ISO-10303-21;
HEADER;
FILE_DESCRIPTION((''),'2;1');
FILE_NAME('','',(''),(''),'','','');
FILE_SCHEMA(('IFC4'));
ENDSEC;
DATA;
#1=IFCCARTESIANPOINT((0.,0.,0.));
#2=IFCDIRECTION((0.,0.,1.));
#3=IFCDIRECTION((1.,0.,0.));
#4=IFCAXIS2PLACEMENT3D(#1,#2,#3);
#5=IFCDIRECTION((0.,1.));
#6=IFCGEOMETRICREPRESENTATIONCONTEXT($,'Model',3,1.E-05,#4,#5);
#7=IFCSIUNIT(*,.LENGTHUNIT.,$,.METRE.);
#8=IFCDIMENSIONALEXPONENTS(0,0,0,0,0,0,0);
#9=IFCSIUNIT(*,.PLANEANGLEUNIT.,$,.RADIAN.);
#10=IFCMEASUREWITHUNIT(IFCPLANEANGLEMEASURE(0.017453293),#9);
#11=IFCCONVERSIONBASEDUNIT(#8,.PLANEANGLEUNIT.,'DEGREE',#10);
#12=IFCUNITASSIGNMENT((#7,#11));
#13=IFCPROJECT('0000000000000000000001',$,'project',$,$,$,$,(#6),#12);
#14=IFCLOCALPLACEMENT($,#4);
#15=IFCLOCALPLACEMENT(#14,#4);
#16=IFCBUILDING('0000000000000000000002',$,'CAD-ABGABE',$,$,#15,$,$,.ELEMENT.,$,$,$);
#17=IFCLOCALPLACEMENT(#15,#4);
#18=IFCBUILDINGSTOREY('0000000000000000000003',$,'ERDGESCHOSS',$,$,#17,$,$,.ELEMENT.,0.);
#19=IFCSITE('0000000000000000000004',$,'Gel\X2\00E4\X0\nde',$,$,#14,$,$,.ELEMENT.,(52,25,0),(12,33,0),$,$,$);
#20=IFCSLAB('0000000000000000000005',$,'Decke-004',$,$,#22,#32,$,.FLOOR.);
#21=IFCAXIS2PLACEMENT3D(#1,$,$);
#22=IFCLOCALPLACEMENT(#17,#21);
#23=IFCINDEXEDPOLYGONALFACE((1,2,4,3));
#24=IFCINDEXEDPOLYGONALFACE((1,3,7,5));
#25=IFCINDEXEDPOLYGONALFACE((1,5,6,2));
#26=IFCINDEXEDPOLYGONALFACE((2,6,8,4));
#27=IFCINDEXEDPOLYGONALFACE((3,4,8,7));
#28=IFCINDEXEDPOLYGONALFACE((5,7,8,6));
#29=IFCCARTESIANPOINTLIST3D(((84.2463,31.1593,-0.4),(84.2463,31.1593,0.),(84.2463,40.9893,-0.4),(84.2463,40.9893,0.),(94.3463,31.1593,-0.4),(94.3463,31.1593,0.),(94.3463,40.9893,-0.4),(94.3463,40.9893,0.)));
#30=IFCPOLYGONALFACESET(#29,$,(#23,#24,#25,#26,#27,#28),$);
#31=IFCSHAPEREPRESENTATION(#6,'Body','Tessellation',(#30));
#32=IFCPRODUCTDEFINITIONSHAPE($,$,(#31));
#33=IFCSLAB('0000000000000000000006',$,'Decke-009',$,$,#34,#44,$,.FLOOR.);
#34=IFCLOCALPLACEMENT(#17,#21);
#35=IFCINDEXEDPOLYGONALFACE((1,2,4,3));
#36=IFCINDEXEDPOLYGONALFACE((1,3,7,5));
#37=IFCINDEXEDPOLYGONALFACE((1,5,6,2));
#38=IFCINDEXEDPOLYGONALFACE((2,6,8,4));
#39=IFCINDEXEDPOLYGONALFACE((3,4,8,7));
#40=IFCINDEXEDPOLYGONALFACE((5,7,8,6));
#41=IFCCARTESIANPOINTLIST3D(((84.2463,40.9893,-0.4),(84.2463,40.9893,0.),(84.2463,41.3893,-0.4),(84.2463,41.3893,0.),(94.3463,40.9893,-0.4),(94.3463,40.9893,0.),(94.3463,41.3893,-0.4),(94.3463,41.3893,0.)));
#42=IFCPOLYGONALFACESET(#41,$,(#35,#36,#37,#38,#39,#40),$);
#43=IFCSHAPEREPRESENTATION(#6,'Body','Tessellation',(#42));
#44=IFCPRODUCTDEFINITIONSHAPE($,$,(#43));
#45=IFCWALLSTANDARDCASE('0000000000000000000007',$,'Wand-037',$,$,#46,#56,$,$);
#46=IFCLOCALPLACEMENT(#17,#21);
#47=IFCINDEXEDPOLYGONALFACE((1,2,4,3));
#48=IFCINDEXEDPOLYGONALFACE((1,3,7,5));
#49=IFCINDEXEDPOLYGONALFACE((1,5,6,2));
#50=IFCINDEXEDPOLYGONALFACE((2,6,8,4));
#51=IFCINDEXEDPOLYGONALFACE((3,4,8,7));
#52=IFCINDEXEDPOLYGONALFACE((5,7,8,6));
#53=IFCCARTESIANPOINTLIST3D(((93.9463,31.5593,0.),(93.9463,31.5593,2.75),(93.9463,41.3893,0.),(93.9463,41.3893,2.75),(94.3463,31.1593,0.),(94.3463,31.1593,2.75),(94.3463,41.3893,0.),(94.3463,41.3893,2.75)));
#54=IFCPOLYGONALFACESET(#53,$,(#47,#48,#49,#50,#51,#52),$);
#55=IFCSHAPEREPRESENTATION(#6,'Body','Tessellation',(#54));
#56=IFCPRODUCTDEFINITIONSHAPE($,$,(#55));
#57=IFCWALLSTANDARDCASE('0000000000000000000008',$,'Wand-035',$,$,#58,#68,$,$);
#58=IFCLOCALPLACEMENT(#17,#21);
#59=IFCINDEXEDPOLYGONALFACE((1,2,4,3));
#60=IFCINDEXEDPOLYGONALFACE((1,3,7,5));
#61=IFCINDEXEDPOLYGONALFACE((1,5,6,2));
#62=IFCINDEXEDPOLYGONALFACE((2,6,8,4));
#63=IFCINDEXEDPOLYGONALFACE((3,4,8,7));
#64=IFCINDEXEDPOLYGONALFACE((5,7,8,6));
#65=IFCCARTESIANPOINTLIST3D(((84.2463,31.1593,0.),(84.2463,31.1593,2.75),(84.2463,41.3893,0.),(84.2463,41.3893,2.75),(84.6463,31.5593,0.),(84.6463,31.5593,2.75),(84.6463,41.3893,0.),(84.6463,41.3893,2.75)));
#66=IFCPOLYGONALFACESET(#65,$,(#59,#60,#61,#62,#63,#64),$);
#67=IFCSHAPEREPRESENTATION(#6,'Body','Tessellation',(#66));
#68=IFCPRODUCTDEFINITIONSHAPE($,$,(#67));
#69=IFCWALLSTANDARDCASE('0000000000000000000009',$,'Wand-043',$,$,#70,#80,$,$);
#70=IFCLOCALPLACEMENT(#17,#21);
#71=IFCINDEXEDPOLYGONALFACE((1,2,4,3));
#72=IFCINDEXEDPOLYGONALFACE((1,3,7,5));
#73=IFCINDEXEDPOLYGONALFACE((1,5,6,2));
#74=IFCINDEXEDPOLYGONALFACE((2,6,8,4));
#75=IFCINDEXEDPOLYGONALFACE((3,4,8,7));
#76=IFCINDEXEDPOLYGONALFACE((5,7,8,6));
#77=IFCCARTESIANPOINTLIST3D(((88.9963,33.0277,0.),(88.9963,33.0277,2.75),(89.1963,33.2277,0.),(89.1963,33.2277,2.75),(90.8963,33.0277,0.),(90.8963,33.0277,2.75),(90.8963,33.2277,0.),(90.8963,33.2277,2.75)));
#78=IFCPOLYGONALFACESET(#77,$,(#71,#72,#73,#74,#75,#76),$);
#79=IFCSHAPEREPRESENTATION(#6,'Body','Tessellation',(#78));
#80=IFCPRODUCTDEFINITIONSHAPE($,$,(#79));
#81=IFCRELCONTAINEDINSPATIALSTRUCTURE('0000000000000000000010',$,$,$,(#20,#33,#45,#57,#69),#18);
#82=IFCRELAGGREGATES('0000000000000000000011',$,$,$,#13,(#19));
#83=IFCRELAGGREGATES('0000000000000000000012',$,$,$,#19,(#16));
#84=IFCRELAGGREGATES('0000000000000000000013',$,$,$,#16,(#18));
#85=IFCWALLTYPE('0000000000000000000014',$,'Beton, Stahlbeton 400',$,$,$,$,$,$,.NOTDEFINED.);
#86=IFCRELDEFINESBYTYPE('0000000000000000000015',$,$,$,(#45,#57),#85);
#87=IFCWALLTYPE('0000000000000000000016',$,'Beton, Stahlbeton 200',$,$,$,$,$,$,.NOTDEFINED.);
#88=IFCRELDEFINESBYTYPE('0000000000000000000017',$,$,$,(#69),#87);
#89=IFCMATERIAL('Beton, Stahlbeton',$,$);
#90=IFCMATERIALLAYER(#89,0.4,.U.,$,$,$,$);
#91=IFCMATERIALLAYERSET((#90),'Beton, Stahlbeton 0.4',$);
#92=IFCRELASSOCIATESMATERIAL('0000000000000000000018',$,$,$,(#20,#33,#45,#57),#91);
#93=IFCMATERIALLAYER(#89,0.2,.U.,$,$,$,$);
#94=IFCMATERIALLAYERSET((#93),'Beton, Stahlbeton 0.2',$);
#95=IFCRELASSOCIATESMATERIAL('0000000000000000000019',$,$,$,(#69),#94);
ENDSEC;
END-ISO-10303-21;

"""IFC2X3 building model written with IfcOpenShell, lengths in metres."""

from ifc_helpers import new_model, entity, si_unit, converted_unit, direction, frame, origin_with_axes, place, context, project, spatial, polyline, outline, extrude, material, layer, layer_set, layer_usage, type_object, element, save


model = new_model("IFC2X3")

# Units and contexts
model_context = context("Model", 3, precision=1e-05, world=origin_with_axes(), true_north=direction((0.0, 1.0)))
ifc_project = project(units=[si_unit("LENGTHUNIT", "METRE"), converted_unit("PLANEANGLEUNIT", "DEGREE", entity("IfcPlaneAngleMeasure", 0.017453293), si_unit("PLANEANGLEUNIT", "RADIAN"), dimensions=[0, 0, 0, 0, 0, 0, 0])], contexts=[model_context])

# Site, building, storey
site_placement = place(None, origin_with_axes())
site = spatial("IfcSite", under=ifc_project, at=site_placement, Name="Gelände", CompositionType="ELEMENT", RefLatitude=(52, 25, 0), RefLongitude=(12, 33, 0))
building_placement = place(site_placement, origin_with_axes())
building = spatial("IfcBuilding", under=site, at=building_placement, Name="CAD-ABGABE", CompositionType="ELEMENT")
storey_placement = place(building_placement, origin_with_axes())
storey = spatial("IfcBuildingStorey", under=building, at=storey_placement, Name="ERDGESCHOSS", CompositionType="ELEMENT", Elevation=0.0)

# Slabs
ifc_material = material(Name="Beton, Stahlbeton")
ifc_layer_1 = layer(ifc_material, 0.4, ventilated="UNKNOWN")
ifc_layer_set_1 = layer_set([ifc_layer_1], Name="Beton, Stahlbeton 0.4")
ifc_layer_usage_1 = layer_usage(ifc_layer_set_1, "AXIS3", "NEGATIVE", 0.4)
slab_1_placement = place(storey_placement, frame((84.2463, 31.1593, -0.4), z_axis=(0.0, 0.0, 1.0), x_axis=(1.0, 0.0, 0.0)))
element("IfcSlab", 1, at=slab_1_placement, inside=storey, material=ifc_layer_usage_1, Name="Decke-004", PredefinedType="FLOOR", context=model_context, shape_type="SweptSolid", body=[
    extrude(outline(polyline([(0.0, 0.0), (10.1, 0.0), (10.1, 9.83), (0.0, 9.83), (0.0, 0.0)])), origin_with_axes(), (0.0, 0.0, 1.0), 0.4),
])
ifc_layer_usage_2 = layer_usage(ifc_layer_set_1, "AXIS3", "NEGATIVE", 0.4)
slab_2_placement = place(storey_placement, frame((84.2463, 40.9893, -0.4), z_axis=(0.0, 0.0, 1.0), x_axis=(1.0, 0.0, 0.0)))
element("IfcSlab", 2, at=slab_2_placement, inside=storey, material=ifc_layer_usage_2, Name="Decke-009", PredefinedType="FLOOR", context=model_context, shape_type="SweptSolid", body=[
    extrude(outline(polyline([(0.0, 0.0), (10.1, 0.0), (10.1, 0.4), (0.0, 0.4), (0.0, 0.0)])), origin_with_axes(), (0.0, 0.0, 1.0), 0.4),
])

# Wall
ifc_layer_usage_3 = layer_usage(ifc_layer_set_1, "AXIS2", "POSITIVE", 0.0)
wall_type_1 = type_object("IfcWallType", Name="Beton, Stahlbeton 400", PredefinedType="NOTDEFINED")
wall_1_placement = place(storey_placement, frame((94.3463, 31.1593, 0.0), z_axis=(0.0, 0.0, 1.0), x_axis=(0.0, 1.0, 0.0)))
element("IfcWallStandardCase", 3, at=wall_1_placement, inside=storey, type_object=wall_type_1, material=ifc_layer_usage_3, Name="Wand-037", context=model_context, shape_type="SweptSolid", body=[
    extrude(outline(polyline([(0.0, 0.0), (10.23, 0.0), (10.23, 0.4), (0.4, 0.4), (0.0, 0.0)])), origin_with_axes(), (0.0, 0.0, 1.0), 2.75),
])

# Wall
ifc_layer_usage_4 = layer_usage(ifc_layer_set_1, "AXIS2", "POSITIVE", 0.0)
wall_2_placement = place(storey_placement, frame((84.2463, 41.3893, 0.0), z_axis=(0.0, 0.0, 1.0), x_axis=(0.0, -1.0, 0.0)))
element("IfcWallStandardCase", 4, at=wall_2_placement, inside=storey, type_object=wall_type_1, material=ifc_layer_usage_4, Name="Wand-035", context=model_context, shape_type="SweptSolid", body=[
    extrude(outline(polyline([(0.0, 0.0), (10.23, 0.0), (9.83, 0.4), (0.0, 0.4), (0.0, 0.0)])), origin_with_axes(), (0.0, 0.0, 1.0), 2.75),
])
ifc_layer_2 = layer(ifc_material, 0.2, ventilated="UNKNOWN")
ifc_layer_set_2 = layer_set([ifc_layer_2], Name="Beton, Stahlbeton 0.2")
wall_type_2 = type_object("IfcWallType", Name="Beton, Stahlbeton 200", PredefinedType="NOTDEFINED")

# Wall
ifc_layer_usage_5 = layer_usage(ifc_layer_set_2, "AXIS2", "NEGATIVE", 0.0)
wall_3_placement = place(storey_placement, frame((88.9963, 33.2277, 0.0), z_axis=(0.0, 0.0, 1.0), x_axis=(1.0, 0.0, 0.0)))
element("IfcWallStandardCase", 5, at=wall_3_placement, inside=storey, type_object=wall_type_2, material=ifc_layer_usage_5, Name="Wand-043", context=model_context, shape_type="SweptSolid", body=[
    extrude(outline(polyline([(0.0, -0.2), (1.9, -0.2), (1.9, 0.0), (0.2, 0.0), (0.0, -0.2)])), origin_with_axes(), (0.0, 0.0, 1.0), 2.75),
])

save(model, "model.ifc")
